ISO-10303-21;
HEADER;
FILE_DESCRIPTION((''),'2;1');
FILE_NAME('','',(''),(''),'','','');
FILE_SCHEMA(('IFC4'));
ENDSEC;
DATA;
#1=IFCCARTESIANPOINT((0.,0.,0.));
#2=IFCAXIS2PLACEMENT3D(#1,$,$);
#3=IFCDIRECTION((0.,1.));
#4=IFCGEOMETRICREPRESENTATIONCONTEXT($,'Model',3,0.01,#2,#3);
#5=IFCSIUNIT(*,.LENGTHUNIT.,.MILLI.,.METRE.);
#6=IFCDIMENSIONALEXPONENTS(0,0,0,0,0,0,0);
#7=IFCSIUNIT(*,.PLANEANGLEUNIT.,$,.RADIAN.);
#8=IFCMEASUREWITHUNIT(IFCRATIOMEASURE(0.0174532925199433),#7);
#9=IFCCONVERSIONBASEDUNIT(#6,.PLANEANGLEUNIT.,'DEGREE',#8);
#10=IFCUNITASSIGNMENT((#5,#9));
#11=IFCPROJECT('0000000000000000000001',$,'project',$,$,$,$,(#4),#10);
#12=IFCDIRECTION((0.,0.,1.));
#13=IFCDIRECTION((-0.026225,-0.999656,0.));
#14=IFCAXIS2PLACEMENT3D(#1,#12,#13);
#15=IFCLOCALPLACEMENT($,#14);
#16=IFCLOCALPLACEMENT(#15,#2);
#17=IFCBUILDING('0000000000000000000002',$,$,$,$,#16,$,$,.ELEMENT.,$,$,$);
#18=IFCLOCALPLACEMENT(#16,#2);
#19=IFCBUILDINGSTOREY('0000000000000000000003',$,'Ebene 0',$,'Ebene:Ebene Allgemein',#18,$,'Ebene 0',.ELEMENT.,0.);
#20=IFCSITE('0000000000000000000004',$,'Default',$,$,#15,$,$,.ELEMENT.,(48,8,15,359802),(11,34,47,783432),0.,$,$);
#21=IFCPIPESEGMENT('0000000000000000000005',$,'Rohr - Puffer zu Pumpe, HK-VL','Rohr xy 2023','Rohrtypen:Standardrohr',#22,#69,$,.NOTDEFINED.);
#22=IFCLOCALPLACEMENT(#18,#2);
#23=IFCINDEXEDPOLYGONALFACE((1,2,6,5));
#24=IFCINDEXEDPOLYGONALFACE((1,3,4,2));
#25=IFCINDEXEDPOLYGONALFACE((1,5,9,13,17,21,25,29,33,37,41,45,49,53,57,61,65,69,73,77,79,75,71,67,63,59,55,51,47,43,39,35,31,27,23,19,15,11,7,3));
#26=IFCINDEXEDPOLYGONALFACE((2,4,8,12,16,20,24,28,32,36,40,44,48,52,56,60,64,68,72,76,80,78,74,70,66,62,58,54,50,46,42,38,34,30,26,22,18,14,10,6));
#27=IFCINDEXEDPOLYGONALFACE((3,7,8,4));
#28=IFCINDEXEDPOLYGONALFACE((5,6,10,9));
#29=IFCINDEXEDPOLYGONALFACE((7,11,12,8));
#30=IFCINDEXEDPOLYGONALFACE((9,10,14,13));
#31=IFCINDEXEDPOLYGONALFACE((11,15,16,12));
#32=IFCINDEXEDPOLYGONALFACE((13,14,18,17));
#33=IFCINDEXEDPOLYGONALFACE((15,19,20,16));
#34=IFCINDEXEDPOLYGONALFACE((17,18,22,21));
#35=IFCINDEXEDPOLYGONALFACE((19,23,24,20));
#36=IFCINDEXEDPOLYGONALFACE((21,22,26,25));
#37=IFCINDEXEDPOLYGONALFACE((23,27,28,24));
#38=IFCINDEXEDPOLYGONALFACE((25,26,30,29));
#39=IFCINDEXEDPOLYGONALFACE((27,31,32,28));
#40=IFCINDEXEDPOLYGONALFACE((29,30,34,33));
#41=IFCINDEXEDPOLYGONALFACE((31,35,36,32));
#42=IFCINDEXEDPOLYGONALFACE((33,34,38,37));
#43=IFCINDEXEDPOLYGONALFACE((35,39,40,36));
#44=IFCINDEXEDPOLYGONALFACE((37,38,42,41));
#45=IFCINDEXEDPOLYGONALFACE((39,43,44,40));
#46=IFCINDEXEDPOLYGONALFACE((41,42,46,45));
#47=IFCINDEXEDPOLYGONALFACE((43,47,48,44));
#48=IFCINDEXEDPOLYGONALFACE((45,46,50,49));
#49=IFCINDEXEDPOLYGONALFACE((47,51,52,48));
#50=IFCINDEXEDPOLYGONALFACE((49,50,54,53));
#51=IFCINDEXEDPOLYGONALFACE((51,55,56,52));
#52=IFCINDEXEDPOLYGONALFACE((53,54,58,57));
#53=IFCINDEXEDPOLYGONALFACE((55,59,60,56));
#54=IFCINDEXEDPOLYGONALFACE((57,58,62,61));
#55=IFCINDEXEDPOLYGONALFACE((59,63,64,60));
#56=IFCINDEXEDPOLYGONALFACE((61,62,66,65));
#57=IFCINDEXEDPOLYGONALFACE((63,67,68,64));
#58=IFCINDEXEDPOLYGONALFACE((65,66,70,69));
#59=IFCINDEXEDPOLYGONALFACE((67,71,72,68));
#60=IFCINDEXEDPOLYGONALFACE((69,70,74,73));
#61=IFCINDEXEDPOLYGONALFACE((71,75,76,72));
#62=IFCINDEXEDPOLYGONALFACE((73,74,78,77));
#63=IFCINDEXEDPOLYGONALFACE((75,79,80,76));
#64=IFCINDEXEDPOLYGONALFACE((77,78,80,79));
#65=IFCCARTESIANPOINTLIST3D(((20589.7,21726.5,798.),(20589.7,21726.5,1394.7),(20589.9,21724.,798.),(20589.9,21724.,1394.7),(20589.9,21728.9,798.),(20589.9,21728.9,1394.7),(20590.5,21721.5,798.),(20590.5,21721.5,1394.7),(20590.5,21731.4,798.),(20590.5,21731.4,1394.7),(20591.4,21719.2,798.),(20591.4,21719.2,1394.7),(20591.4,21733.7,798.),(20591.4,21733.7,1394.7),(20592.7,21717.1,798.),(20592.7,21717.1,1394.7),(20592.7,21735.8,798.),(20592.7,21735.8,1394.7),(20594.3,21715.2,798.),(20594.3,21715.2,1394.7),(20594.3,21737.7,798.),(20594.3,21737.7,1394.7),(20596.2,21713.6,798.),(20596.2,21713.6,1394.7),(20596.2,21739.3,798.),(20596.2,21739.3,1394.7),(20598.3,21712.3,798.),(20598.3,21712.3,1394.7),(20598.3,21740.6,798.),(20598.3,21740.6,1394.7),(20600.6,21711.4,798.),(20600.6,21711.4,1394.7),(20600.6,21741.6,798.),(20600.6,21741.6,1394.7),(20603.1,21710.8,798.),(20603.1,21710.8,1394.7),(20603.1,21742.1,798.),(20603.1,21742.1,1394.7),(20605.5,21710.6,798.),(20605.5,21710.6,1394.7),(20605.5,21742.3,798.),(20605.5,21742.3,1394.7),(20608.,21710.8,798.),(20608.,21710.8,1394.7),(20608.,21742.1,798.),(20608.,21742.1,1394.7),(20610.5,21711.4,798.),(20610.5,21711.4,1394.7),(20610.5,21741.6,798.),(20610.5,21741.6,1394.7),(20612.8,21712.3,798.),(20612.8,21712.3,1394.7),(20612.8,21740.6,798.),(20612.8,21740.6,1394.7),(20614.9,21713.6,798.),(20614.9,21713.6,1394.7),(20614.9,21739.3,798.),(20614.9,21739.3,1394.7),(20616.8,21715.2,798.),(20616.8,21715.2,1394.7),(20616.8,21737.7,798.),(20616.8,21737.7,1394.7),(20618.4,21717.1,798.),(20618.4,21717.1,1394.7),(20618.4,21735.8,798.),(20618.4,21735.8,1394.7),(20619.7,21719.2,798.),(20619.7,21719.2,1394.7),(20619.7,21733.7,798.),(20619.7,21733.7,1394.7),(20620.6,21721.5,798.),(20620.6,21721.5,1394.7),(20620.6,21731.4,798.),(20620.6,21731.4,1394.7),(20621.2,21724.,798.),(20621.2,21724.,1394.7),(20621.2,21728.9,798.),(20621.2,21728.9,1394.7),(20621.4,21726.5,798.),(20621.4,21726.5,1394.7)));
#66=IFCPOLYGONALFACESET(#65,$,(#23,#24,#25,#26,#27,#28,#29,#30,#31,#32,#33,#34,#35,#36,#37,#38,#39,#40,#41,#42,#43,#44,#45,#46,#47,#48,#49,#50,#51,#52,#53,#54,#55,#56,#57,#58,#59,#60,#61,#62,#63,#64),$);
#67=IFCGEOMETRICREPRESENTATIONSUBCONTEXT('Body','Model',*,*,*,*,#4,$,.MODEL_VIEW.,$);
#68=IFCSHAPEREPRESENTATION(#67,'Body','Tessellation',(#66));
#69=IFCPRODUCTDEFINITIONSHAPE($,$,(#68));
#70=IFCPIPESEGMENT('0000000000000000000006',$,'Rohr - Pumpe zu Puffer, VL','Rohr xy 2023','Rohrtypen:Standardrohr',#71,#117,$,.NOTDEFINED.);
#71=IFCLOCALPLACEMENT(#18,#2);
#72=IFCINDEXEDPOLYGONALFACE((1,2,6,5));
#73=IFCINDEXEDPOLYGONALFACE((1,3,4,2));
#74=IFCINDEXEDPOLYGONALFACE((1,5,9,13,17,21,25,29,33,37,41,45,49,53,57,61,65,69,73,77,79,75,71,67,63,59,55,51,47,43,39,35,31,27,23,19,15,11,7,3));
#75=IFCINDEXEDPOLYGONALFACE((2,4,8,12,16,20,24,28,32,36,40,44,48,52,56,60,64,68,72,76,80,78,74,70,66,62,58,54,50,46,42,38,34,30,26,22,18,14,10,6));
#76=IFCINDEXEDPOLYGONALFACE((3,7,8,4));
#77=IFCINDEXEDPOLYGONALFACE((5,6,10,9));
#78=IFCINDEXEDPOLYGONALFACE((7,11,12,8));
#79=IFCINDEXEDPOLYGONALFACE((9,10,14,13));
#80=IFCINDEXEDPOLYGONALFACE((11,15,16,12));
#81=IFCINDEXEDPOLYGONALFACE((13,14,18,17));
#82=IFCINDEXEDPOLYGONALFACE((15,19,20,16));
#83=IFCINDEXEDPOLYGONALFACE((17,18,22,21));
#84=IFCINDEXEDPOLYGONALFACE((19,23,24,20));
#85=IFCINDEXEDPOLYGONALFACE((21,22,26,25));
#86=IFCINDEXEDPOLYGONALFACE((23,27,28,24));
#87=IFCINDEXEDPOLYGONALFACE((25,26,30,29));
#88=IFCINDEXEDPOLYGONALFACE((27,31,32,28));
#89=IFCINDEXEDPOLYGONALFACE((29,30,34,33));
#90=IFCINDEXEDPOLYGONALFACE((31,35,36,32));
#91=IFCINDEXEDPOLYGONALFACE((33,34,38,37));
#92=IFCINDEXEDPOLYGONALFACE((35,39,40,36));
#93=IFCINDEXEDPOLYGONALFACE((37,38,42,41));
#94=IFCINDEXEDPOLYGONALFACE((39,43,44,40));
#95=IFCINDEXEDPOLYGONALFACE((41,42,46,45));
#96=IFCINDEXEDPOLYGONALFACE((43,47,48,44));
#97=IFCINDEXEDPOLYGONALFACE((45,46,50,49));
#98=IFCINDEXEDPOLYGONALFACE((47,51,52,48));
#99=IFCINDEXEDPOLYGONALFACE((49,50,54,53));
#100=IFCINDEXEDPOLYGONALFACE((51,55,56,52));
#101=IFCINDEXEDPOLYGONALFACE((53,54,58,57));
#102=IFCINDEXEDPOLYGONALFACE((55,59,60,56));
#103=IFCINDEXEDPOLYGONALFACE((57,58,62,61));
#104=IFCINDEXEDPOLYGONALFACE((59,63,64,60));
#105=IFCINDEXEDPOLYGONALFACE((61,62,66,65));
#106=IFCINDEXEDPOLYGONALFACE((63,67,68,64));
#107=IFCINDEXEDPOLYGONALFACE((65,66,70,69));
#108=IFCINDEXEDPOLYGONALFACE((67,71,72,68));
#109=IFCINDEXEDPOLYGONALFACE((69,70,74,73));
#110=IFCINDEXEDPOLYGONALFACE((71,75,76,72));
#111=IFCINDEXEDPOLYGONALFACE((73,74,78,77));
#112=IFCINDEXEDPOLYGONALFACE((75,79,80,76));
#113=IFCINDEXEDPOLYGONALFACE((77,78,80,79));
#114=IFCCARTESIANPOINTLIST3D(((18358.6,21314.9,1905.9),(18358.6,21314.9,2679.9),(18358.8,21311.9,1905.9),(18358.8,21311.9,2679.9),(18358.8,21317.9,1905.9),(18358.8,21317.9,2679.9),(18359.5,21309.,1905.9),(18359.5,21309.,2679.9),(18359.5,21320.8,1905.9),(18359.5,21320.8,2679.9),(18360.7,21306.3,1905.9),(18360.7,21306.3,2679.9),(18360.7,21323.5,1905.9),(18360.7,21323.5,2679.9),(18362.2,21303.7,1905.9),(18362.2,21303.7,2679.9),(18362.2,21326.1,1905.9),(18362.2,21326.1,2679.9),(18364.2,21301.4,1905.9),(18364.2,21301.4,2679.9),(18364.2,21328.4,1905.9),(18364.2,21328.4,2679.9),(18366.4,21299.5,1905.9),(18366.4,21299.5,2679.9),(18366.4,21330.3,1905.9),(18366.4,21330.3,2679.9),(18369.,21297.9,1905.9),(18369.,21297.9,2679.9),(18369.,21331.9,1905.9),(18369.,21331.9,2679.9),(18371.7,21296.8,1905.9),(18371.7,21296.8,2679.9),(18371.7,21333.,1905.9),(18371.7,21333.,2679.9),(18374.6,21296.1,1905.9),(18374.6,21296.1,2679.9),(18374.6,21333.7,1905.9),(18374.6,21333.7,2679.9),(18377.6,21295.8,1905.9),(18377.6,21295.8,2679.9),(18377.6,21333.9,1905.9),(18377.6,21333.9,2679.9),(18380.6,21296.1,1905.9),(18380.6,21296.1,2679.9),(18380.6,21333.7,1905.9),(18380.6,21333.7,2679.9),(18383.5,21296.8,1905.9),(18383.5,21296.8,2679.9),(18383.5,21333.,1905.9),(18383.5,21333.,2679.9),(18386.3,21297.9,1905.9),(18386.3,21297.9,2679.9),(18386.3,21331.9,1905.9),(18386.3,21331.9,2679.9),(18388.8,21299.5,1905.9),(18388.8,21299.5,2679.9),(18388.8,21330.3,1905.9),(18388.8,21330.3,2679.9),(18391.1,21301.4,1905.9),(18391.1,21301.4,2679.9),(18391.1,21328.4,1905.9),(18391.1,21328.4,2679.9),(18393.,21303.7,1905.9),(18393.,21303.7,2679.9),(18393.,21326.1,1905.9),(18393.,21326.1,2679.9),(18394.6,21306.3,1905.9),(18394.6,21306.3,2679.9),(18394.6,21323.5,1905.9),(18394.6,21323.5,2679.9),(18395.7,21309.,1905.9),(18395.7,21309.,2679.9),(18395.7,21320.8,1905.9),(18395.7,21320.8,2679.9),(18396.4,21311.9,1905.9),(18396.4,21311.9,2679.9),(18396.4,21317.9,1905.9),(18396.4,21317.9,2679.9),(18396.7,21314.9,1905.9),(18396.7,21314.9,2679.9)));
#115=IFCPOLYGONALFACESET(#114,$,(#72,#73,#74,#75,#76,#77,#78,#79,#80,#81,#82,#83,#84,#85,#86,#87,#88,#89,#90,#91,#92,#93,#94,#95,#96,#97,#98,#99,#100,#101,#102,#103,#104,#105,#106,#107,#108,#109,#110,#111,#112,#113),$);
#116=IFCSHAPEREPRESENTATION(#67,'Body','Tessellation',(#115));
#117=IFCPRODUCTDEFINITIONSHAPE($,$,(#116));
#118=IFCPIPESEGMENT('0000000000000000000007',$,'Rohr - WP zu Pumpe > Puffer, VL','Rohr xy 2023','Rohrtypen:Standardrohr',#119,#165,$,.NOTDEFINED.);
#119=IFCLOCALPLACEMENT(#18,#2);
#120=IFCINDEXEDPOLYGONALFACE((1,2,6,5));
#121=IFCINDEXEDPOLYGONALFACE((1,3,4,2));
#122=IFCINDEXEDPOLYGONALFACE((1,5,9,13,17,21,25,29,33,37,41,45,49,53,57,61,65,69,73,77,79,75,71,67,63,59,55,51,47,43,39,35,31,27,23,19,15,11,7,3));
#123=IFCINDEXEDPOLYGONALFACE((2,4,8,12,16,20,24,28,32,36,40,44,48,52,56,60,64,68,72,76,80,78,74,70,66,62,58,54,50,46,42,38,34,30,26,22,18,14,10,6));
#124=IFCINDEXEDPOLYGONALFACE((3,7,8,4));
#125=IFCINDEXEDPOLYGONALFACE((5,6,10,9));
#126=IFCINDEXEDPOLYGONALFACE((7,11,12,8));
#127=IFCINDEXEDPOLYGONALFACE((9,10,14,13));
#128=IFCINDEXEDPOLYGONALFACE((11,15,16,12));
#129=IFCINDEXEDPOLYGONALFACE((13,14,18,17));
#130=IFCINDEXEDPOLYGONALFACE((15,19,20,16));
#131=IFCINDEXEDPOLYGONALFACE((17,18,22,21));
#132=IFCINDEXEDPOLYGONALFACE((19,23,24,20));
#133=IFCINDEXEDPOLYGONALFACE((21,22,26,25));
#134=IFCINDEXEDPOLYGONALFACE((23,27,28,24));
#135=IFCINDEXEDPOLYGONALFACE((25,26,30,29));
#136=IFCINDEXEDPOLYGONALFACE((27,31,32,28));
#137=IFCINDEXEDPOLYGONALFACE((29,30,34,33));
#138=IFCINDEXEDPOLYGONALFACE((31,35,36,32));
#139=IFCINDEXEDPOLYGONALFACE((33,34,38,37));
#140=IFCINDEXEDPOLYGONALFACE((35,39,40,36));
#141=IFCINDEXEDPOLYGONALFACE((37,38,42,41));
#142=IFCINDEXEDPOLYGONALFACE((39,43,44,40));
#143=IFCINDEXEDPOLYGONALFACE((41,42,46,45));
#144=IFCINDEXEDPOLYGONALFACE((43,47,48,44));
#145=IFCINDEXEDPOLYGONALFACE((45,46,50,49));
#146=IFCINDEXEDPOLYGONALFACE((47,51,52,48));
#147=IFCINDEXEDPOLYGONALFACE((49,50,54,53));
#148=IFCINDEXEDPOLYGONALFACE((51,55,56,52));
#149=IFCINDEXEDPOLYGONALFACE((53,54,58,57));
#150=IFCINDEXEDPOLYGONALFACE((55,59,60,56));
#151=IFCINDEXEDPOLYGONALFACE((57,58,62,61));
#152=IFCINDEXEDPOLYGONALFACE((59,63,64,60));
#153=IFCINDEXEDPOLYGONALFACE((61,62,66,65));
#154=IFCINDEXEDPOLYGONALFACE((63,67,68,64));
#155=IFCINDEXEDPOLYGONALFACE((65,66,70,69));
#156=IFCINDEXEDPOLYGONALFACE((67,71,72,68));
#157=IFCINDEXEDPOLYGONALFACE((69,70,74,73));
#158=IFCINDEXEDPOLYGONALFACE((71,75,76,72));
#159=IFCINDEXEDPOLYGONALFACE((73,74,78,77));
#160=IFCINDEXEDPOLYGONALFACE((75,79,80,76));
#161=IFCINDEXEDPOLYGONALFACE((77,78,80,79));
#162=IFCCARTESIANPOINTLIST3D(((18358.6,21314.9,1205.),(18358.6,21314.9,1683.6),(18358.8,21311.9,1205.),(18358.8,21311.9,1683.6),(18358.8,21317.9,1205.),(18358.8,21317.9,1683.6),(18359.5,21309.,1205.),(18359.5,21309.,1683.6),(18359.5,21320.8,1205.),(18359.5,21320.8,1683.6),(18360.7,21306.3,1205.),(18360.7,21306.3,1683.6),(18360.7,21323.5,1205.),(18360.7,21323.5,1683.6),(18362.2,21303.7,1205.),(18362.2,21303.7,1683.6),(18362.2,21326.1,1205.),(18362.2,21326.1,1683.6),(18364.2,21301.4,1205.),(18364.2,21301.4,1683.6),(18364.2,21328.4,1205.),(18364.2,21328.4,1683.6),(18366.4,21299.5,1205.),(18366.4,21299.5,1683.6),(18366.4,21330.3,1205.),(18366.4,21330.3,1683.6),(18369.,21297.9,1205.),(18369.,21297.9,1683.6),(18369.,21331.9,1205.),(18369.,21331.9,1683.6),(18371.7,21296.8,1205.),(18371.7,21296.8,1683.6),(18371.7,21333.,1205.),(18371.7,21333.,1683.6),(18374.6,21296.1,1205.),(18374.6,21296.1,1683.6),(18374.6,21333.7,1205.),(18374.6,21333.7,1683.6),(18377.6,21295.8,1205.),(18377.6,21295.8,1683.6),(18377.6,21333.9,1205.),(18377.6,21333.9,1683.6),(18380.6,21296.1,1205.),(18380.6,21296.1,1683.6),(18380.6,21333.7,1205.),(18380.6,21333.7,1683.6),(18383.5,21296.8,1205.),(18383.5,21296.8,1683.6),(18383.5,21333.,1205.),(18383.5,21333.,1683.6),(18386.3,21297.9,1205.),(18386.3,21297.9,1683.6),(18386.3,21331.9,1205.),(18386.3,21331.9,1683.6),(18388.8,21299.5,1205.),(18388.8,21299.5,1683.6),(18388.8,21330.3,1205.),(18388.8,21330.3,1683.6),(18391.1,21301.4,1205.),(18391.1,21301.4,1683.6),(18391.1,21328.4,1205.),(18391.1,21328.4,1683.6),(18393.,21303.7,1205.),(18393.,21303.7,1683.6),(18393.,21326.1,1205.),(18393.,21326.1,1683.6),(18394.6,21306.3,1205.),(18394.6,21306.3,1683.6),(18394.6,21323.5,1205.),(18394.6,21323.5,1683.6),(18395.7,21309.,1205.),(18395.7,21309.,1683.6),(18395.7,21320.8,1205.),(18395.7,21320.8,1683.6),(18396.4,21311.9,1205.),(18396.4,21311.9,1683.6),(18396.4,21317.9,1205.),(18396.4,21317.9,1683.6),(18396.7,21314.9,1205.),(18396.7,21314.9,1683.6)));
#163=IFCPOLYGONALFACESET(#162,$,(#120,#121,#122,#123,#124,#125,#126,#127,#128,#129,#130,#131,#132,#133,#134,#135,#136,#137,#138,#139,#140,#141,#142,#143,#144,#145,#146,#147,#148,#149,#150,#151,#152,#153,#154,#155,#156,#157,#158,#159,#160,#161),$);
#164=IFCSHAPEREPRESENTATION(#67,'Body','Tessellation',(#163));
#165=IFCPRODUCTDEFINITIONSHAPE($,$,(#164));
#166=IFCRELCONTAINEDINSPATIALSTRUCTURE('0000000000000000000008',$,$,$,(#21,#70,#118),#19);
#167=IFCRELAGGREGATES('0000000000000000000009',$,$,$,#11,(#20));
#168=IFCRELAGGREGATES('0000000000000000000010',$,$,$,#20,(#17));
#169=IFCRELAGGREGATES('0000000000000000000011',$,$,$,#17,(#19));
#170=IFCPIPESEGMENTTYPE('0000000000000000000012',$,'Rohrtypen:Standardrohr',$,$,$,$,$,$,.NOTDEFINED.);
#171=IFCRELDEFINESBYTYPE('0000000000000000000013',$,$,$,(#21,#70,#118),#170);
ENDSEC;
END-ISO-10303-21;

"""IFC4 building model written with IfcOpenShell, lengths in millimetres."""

from ifc_helpers import new_model, entity, si_unit, converted_unit, direction, frame, origin, place, context, subcontext, project, spatial, indexed_curve, outline, extrude, type_object, element, save


model = new_model("IFC4")

# Units and contexts
model_context = context("Model", 3, precision=0.01, world=origin(), true_north=direction((0.0, 1.0)))
body_context = subcontext(model_context, "Body", "Model", "MODEL_VIEW")
ifc_project = project(units=[si_unit("LENGTHUNIT", "METRE", prefix="MILLI"), converted_unit("PLANEANGLEUNIT", "DEGREE", entity("IfcRatioMeasure", 0.0174532925199433), si_unit("PLANEANGLEUNIT", "RADIAN"), dimensions=[0, 0, 0, 0, 0, 0, 0])], contexts=[model_context])

# Site, building, storey
site_placement = place(None, frame((0.0, 0.0, 0.0), z_axis=(0.0, 0.0, 1.0), x_axis=(-0.026225, -0.999656, 0.0)))
site = spatial("IfcSite", under=ifc_project, at=site_placement, Name="Default", CompositionType="ELEMENT", RefLatitude=(48, 8, 15, 359802), RefLongitude=(11, 34, 47, 783432), RefElevation=0.0)
building_placement = place(site_placement, origin())
building = spatial("IfcBuilding", under=site, at=building_placement, CompositionType="ELEMENT")
storey_placement = place(building_placement, origin())
storey = spatial("IfcBuildingStorey", under=building, at=storey_placement, Name="Ebene 0", ObjectType="Ebene:Ebene Allgemein", LongName="Ebene 0", CompositionType="ELEMENT", Elevation=0.0)

# Pipe segments
pipe_segment_type = type_object("IfcPipeSegmentType", Name="Rohrtypen:Standardrohr", PredefinedType="NOTDEFINED")
pipe_segment_1_placement = place(storey_placement, origin())
element("IfcPipeSegment", 1, at=pipe_segment_1_placement, inside=storey, type_object=pipe_segment_type, Name="Rohr - Puffer zu Pumpe, HK-VL", Description="Rohr xy 2023", ObjectType="Rohrtypen:Standardrohr", PredefinedType="NOTDEFINED", context=body_context, shape_type="SweptSolid", body=[
    extrude(outline(indexed_curve([(15.9, 0.0), (15.7, 2.5), (15.1, 4.9), (14.1, 7.2), (12.8, 9.3), (11.2, 11.2), (9.3, 12.8), (7.2, 14.1), (4.9, 15.1), (2.5, 15.7), (0.0, 15.9), (-2.5, 15.7), (-4.9, 15.1), (-7.2, 14.1), (-9.3, 12.8), (-11.2, 11.2), (-12.8, 9.3), (-14.1, 7.2), (-15.1, 4.9), (-15.7, 2.5), (-15.9, 0.0), (-15.7, -2.5), (-15.1, -4.9), (-14.1, -7.2), (-12.8, -9.3), (-11.2, -11.2), (-9.3, -12.8), (-7.2, -14.1), (-4.9, -15.1), (-2.5, -15.7), (0.0, -15.9), (2.5, -15.7), (4.9, -15.1), (7.2, -14.1), (9.3, -12.8), (11.2, -11.2), (12.8, -9.3), (14.1, -7.2), (15.1, -4.9), (15.7, -2.5), (15.9, 0.0)], self_intersect=False)), frame((20605.5, 21726.5, 798.0), z_axis=(0.0, 0.0, 1.0), x_axis=(-1.0, 0.0, 0.0)), (0.0, 0.0, 1.0), 596.7),
])
pipe_segment_2_placement = place(storey_placement, origin())
element("IfcPipeSegment", 2, at=pipe_segment_2_placement, inside=storey, type_object=pipe_segment_type, Name="Rohr - Pumpe zu Puffer, VL", Description="Rohr xy 2023", ObjectType="Rohrtypen:Standardrohr", PredefinedType="NOTDEFINED", context=body_context, shape_type="SweptSolid", body=[
    extrude(outline(indexed_curve([(19.1, 0.0), (18.8, 3.0), (18.1, 5.9), (17.0, 8.6), (15.4, 11.2), (13.5, 13.5), (11.2, 15.4), (8.6, 17.0), (5.9, 18.1), (3.0, 18.8), (0.0, 19.1), (-3.0, 18.8), (-5.9, 18.1), (-8.6, 17.0), (-11.2, 15.4), (-13.5, 13.5), (-15.4, 11.2), (-17.0, 8.6), (-18.1, 5.9), (-18.8, 3.0), (-19.1, 0.0), (-18.8, -3.0), (-18.1, -5.9), (-17.0, -8.6), (-15.4, -11.2), (-13.5, -13.5), (-11.2, -15.4), (-8.6, -17.0), (-5.9, -18.1), (-3.0, -18.8), (0.0, -19.1), (3.0, -18.8), (5.9, -18.1), (8.6, -17.0), (11.2, -15.4), (13.5, -13.5), (15.4, -11.2), (17.0, -8.6), (18.1, -5.9), (18.8, -3.0), (19.1, 0.0)], self_intersect=False)), frame((18377.6, 21314.9, 1905.9), z_axis=(0.0, 0.0, 1.0), x_axis=(-1.0, 0.0, 0.0)), (0.0, 0.0, 1.0), 774.0),
])
pipe_segment_3_placement = place(storey_placement, origin())
element("IfcPipeSegment", 3, at=pipe_segment_3_placement, inside=storey, type_object=pipe_segment_type, Name="Rohr - WP zu Pumpe > Puffer, VL", Description="Rohr xy 2023", ObjectType="Rohrtypen:Standardrohr", PredefinedType="NOTDEFINED", context=body_context, shape_type="SweptSolid", body=[
    extrude(outline(indexed_curve([(19.1, 0.0), (18.8, 3.0), (18.1, 5.9), (17.0, 8.6), (15.4, 11.2), (13.5, 13.5), (11.2, 15.4), (8.6, 17.0), (5.9, 18.1), (3.0, 18.8), (0.0, 19.1), (-3.0, 18.8), (-5.9, 18.1), (-8.6, 17.0), (-11.2, 15.4), (-13.5, 13.5), (-15.4, 11.2), (-17.0, 8.6), (-18.1, 5.9), (-18.8, 3.0), (-19.1, 0.0), (-18.8, -3.0), (-18.1, -5.9), (-17.0, -8.6), (-15.4, -11.2), (-13.5, -13.5), (-11.2, -15.4), (-8.6, -17.0), (-5.9, -18.1), (-3.0, -18.8), (0.0, -19.1), (3.0, -18.8), (5.9, -18.1), (8.6, -17.0), (11.2, -15.4), (13.5, -13.5), (15.4, -11.2), (17.0, -8.6), (18.1, -5.9), (18.8, -3.0), (19.1, 0.0)], self_intersect=False)), frame((18377.6, 21314.9, 1205.0), z_axis=(0.0, 0.0, 1.0), x_axis=(-1.0, 0.0, 0.0)), (0.0, 0.0, 1.0), 478.6),
])

save(model, "model.ifc")
